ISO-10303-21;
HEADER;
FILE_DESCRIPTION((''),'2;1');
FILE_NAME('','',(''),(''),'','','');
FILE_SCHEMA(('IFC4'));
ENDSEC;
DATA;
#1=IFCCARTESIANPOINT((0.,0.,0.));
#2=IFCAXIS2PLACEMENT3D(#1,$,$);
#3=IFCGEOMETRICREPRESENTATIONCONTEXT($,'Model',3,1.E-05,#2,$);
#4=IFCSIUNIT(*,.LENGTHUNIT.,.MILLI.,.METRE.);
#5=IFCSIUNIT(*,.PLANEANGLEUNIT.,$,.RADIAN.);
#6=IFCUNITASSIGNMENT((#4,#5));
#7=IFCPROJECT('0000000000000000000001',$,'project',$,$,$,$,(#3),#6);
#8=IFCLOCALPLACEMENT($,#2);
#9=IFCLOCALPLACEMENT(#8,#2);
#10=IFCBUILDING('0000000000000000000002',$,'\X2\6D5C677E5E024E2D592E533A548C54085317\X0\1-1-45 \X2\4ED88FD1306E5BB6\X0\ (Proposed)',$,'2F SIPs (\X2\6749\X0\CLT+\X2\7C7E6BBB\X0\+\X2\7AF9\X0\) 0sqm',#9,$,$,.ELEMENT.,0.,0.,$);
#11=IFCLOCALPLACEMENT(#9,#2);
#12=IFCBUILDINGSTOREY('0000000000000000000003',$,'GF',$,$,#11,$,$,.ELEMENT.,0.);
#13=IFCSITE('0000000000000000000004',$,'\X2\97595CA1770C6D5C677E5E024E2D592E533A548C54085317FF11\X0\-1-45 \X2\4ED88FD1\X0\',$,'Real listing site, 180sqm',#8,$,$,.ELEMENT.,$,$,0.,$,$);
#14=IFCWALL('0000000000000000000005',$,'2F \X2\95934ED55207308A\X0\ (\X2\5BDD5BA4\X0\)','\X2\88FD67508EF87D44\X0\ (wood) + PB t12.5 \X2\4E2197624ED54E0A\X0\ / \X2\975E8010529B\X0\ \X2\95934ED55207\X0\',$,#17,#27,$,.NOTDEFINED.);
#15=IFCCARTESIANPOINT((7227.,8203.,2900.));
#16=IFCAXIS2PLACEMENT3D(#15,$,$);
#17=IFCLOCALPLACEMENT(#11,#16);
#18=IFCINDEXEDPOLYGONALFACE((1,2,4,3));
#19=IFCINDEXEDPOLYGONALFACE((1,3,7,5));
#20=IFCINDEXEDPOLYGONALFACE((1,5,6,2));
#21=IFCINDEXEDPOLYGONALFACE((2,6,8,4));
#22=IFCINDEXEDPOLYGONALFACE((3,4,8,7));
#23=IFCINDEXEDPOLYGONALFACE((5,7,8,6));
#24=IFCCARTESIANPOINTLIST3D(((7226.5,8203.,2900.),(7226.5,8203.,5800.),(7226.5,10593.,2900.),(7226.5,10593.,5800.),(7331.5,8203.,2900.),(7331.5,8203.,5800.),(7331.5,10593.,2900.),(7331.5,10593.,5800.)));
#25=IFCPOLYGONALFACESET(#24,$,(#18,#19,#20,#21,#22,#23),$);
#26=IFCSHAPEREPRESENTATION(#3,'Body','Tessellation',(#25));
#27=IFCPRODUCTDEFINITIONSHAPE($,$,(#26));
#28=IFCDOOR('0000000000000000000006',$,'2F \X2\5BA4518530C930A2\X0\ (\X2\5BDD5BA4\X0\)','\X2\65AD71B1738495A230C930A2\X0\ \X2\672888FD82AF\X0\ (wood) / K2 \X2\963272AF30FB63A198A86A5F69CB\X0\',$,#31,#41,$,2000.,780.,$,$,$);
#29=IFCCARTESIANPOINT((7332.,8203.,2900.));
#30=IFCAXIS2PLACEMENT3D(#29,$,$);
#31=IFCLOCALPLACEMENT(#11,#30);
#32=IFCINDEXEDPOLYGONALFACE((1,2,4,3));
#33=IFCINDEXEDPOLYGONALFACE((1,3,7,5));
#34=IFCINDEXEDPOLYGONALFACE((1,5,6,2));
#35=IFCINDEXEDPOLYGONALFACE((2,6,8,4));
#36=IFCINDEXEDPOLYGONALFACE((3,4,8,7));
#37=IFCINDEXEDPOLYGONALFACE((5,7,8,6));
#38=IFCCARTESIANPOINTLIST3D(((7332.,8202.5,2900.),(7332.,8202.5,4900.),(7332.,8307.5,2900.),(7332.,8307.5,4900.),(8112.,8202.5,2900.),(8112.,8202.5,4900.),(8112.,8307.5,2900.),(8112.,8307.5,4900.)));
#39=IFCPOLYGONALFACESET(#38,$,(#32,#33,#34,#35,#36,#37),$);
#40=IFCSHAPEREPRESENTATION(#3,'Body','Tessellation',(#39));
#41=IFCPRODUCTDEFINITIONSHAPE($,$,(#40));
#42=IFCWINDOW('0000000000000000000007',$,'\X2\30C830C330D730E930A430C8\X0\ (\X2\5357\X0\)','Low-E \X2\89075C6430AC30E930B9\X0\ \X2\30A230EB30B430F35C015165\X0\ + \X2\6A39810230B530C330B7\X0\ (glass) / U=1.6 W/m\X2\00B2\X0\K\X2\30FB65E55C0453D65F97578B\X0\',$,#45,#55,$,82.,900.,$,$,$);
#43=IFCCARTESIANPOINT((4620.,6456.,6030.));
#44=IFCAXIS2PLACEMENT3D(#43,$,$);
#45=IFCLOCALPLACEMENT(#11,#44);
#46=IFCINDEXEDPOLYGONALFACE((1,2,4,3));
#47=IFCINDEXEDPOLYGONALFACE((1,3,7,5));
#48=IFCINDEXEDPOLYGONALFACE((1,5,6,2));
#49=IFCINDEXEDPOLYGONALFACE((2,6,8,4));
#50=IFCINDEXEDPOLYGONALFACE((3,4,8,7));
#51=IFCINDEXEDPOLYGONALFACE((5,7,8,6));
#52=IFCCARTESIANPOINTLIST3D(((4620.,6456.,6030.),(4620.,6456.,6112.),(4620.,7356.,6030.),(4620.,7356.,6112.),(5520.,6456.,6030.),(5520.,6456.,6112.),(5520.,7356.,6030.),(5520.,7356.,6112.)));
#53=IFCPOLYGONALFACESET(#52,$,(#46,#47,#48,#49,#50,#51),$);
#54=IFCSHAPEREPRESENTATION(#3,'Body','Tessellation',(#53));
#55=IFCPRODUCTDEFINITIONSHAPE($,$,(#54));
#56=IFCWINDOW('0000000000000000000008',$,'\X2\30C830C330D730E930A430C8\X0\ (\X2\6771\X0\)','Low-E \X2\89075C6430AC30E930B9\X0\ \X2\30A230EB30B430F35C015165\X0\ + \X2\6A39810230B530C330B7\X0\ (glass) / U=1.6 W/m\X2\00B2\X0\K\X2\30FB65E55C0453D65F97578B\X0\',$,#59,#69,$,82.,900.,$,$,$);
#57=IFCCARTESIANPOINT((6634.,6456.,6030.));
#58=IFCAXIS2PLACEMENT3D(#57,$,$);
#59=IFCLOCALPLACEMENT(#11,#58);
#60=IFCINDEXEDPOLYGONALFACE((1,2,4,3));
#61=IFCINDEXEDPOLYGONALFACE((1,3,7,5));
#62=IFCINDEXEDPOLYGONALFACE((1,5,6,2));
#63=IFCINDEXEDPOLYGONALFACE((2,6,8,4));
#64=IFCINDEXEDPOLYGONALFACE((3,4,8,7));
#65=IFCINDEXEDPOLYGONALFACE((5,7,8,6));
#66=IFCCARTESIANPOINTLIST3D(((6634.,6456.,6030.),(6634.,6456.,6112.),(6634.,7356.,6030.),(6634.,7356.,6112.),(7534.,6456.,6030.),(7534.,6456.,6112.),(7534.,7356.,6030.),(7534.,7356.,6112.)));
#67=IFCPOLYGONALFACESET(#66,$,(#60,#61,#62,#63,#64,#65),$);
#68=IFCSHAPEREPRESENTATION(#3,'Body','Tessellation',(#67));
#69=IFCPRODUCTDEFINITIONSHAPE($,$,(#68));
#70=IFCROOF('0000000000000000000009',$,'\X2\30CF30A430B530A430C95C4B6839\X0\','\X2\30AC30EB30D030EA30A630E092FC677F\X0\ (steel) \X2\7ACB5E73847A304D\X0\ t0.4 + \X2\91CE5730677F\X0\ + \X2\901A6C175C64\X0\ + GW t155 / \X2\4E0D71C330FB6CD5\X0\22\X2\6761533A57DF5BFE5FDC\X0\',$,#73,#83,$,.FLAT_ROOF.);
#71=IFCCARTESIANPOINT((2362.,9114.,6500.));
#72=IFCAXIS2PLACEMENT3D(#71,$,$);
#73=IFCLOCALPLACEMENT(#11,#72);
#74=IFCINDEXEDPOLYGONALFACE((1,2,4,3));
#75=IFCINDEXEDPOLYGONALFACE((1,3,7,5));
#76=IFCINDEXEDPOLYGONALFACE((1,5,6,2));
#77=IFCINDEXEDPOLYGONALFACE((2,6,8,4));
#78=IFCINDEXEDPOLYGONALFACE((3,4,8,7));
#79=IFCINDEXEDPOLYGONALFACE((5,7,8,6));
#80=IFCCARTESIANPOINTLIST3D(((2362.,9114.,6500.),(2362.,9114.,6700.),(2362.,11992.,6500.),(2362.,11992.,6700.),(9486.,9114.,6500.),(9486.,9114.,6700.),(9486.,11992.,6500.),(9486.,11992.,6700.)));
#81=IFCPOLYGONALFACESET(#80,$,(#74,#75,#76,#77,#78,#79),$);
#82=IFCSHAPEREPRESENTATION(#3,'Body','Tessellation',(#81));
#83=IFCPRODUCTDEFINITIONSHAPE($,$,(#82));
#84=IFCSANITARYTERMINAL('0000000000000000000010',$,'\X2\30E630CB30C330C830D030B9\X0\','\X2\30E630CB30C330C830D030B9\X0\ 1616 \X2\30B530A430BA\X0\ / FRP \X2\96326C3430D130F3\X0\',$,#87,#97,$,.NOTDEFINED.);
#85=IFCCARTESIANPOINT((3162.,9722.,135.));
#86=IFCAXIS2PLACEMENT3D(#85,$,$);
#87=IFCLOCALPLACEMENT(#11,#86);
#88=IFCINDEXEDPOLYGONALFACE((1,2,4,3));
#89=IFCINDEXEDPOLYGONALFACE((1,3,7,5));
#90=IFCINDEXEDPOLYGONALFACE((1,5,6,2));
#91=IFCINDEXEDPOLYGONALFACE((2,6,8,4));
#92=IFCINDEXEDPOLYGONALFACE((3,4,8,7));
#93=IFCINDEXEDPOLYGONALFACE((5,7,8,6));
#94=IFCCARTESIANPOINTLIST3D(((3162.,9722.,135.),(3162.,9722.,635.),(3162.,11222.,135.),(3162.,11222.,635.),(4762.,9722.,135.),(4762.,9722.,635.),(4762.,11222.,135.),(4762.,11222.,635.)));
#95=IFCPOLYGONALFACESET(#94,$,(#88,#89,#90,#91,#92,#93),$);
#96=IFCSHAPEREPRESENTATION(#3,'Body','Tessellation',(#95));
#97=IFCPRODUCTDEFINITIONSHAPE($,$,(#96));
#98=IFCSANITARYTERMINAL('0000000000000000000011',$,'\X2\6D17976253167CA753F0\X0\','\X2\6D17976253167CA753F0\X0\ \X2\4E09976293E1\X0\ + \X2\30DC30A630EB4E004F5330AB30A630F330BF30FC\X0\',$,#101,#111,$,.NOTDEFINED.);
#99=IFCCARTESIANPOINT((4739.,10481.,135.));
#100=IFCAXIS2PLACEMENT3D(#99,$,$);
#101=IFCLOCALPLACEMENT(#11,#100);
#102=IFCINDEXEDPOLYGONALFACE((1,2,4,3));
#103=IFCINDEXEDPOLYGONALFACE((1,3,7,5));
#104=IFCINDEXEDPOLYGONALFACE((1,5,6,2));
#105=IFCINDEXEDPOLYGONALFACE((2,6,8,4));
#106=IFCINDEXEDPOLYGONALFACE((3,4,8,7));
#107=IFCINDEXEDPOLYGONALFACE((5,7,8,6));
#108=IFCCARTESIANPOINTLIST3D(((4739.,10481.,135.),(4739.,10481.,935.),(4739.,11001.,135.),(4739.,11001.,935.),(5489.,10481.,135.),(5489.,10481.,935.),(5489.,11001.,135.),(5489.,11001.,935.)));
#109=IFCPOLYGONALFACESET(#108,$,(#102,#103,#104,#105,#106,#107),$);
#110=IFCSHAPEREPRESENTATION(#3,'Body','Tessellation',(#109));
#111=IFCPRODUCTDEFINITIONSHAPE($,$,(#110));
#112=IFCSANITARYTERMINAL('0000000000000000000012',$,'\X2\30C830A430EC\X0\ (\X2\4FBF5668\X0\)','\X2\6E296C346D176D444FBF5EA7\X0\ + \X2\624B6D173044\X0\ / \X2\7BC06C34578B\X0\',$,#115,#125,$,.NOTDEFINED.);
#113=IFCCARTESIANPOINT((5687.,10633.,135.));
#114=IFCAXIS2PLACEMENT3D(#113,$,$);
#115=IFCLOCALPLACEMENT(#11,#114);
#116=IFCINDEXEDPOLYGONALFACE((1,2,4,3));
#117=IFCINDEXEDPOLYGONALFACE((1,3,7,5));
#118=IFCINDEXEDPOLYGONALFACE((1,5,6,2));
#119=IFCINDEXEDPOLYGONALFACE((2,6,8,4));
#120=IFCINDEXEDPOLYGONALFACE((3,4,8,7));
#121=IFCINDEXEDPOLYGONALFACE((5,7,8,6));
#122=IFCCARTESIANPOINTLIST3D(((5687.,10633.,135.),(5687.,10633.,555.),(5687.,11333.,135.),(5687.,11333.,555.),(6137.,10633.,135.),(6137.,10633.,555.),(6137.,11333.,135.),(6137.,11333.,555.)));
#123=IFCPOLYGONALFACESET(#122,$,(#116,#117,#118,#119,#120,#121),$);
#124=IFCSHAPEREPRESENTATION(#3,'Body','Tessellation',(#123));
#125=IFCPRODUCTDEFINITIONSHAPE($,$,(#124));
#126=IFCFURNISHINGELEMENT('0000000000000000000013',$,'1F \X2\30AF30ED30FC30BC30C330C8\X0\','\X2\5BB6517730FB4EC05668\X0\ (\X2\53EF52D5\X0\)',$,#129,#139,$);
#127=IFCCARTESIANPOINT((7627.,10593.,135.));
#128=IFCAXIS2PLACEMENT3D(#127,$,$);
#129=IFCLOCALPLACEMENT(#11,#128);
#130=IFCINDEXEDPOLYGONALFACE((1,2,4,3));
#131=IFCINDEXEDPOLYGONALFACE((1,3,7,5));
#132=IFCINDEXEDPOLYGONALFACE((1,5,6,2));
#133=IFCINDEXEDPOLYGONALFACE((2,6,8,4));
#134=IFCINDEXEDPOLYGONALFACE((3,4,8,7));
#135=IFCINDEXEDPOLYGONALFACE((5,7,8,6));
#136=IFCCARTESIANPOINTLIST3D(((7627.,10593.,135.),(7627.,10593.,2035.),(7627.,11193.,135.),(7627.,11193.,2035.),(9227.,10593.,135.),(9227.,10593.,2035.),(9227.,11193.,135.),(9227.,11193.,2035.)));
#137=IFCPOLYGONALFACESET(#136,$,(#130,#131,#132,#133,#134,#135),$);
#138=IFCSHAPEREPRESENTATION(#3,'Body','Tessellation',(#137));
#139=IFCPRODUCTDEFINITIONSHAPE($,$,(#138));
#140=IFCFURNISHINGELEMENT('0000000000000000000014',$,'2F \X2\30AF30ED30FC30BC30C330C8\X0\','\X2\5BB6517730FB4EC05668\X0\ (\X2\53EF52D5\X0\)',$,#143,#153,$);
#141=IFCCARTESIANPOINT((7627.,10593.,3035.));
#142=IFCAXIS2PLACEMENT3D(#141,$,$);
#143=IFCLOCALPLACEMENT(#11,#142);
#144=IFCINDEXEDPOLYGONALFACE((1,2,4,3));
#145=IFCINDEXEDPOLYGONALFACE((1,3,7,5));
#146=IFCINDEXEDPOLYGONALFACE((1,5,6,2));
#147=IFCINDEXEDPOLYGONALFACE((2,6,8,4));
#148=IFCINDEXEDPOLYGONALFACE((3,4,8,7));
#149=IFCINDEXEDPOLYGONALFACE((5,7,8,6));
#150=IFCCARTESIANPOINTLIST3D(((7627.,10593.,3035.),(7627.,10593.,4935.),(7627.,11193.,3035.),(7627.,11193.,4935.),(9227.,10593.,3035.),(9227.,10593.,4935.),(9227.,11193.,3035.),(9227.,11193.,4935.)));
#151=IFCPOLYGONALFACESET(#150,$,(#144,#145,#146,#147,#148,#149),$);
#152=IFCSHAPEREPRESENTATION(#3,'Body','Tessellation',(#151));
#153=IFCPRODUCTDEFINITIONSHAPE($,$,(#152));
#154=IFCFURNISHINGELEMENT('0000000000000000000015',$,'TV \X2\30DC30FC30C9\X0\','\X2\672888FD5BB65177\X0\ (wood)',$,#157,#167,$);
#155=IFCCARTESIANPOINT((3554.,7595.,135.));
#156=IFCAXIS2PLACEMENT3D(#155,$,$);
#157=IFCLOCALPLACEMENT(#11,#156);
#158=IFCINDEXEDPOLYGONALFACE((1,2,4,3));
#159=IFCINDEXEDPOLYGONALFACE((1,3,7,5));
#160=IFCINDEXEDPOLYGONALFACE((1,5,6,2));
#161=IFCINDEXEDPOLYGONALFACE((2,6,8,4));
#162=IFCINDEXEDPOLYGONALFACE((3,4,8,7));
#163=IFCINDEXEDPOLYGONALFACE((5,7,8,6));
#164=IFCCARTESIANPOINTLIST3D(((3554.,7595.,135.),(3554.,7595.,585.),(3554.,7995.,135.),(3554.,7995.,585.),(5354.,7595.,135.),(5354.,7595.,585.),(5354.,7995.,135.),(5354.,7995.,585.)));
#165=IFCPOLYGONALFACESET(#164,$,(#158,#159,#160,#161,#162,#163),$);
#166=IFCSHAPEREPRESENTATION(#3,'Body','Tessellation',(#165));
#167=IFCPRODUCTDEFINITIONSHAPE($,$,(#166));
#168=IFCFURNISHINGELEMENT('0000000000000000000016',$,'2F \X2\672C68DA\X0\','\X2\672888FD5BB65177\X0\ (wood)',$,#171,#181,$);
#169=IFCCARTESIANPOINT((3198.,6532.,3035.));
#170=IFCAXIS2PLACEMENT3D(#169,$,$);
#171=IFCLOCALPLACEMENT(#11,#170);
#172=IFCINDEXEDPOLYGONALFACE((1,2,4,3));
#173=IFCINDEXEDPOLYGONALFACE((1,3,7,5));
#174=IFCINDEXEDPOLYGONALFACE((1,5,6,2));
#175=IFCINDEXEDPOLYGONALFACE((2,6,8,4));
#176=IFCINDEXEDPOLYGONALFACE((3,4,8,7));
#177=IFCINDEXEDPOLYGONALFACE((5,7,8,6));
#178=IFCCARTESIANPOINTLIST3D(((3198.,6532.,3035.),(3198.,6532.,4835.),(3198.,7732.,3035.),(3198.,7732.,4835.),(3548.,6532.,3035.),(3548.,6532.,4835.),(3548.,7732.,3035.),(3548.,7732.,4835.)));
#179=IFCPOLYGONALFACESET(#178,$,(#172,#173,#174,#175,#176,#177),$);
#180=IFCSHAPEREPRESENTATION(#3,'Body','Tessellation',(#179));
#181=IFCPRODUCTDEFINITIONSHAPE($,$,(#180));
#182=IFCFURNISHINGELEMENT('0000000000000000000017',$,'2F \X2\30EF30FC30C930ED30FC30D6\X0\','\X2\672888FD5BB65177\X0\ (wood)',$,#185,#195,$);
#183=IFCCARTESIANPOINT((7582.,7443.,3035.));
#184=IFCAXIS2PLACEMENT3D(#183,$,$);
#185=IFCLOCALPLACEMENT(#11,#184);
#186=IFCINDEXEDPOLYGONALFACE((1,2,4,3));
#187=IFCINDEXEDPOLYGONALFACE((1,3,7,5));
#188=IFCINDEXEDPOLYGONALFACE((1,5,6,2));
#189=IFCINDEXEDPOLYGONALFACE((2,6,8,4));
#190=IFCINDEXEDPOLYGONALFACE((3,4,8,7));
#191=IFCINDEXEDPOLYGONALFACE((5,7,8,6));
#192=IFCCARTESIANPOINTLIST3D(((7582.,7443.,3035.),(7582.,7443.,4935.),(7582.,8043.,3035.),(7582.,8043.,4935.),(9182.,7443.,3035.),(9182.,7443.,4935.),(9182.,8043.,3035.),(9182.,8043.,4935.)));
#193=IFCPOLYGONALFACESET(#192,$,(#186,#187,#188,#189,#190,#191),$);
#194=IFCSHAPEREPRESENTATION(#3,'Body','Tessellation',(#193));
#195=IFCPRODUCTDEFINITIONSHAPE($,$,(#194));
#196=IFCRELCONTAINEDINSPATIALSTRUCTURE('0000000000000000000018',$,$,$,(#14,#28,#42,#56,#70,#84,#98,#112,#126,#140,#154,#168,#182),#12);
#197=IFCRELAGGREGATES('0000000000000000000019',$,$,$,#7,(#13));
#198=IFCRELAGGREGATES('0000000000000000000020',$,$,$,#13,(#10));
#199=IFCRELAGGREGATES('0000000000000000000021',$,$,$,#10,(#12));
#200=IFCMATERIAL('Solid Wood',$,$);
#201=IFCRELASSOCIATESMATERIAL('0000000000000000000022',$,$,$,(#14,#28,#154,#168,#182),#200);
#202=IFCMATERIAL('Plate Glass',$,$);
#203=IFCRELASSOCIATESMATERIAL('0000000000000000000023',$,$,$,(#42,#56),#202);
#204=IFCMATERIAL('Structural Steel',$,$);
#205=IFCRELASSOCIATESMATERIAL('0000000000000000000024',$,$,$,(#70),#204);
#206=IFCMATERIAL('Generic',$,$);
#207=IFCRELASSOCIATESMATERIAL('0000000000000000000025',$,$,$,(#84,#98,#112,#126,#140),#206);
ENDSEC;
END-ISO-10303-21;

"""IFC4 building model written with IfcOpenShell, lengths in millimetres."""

from ifc_helpers import new_model, si_unit, frame, frame_2d, origin, place, context, project, spatial, rectangle, extrude, material, element, save


model = new_model("IFC4")

# Units and contexts
model_context = context("Model", 3, precision=1e-05, world=origin())
ifc_project = project(units=[si_unit("LENGTHUNIT", "METRE", prefix="MILLI"), si_unit("PLANEANGLEUNIT", "RADIAN")], contexts=[model_context])

# Site, building, storey
site_placement = place(None, origin())
site = spatial("IfcSite", under=ifc_project, at=site_placement, Name="静岡県浜松市中央区和合北１-1-45 付近", ObjectType="Real listing site, 180sqm", CompositionType="ELEMENT", RefElevation=0.0)
building_placement = place(site_placement, origin())
building = spatial("IfcBuilding", under=site, at=building_placement, Name="浜松市中央区和合北1-1-45 付近の家 (Proposed)", ObjectType="2F SIPs (杉CLT+籾殻+竹) 0sqm", CompositionType="ELEMENT", ElevationOfRefHeight=0.0, ElevationOfTerrain=0.0)
storey_placement = place(building_placement, origin())
storey = spatial("IfcBuildingStorey", under=building, at=storey_placement, Name="GF", CompositionType="ELEMENT", Elevation=0.0)

# Shared definitions
ifc_material_1 = material(Name="Solid Wood")
ifc_material_2 = material(Name="Plate Glass")

# Wall
wall_1_placement = place(storey_placement, frame((7227.0, 8203.0, 2900.0)))
element("IfcWall", 1, at=wall_1_placement, inside=storey, material=ifc_material_1, Name="2F 間仕切り (寝室)", Description="製材軸組 (wood) + PB t12.5 両面仕上 / 非耐力 間仕切", PredefinedType="NOTDEFINED", context=model_context, shape_type="SweptSolid", body=[
    extrude(rectangle(XDim=105.0, YDim=2390.0, at=frame_2d((52.0, 1195.0))), frame((7227.0, 8203.0, 2900.0)), (0.0, 0.0, 1.0), 2900.0),
])

# Door
door_1_placement = place(storey_placement, frame((7332.0, 8203.0, 2900.0)))
element("IfcDoor", 2, at=door_1_placement, inside=storey, material=ifc_material_1, Name="2F 室内ドア (寝室)", Description="断熱玄関ドア 木製芯 (wood) / K2 防犯・採風機構", OverallHeight=2000.0, OverallWidth=780.0, context=model_context, shape_type="SweptSolid", body=[
    extrude(rectangle(XDim=780.0, YDim=105.0, at=frame_2d((390.0, 52.0))), frame((7332.0, 8203.0, 2900.0)), (0.0, 0.0, 1.0), 2000.0),
])

# Windows
window_1_placement = place(storey_placement, frame((4620.0, 6456.0, 6030.0)))
element("IfcWindow", 3, at=window_1_placement, inside=storey, material=ifc_material_2, Name="トップライト (南)", Description="Low-E 複層ガラス アルゴン封入 + 樹脂サッシ (glass) / U=1.6 W/m²K・日射取得型", OverallHeight=82.0, OverallWidth=900.0, context=model_context, shape_type="SweptSolid", body=[
    extrude(rectangle(XDim=900.0, YDim=900.0, at=frame_2d((450.0, 450.0))), frame((4620.0, 6456.0, 6030.0)), (0.0, 0.0, 1.0), 82.0),
])
window_2_placement = place(storey_placement, frame((6634.0, 6456.0, 6030.0)))
element("IfcWindow", 4, at=window_2_placement, inside=storey, material=ifc_material_2, Name="トップライト (東)", Description="Low-E 複層ガラス アルゴン封入 + 樹脂サッシ (glass) / U=1.6 W/m²K・日射取得型", OverallHeight=82.0, OverallWidth=900.0, context=model_context, shape_type="SweptSolid", body=[
    extrude(rectangle(XDim=900.0, YDim=900.0, at=frame_2d((450.0, 450.0))), frame((6634.0, 6456.0, 6030.0)), (0.0, 0.0, 1.0), 82.0),
])

# Roof
ifc_material_3 = material(Name="Structural Steel")
roof_placement = place(storey_placement, frame((2362.0, 9114.0, 6500.0)))
element("IfcRoof", 5, at=roof_placement, inside=storey, material=ifc_material_3, Name="ハイサイド屋根", Description="ガルバリウム鋼板 (steel) 立平葺き t0.4 + 野地板 + 通気層 + GW t155 / 不燃・法22条区域対応", PredefinedType="FLAT_ROOF", context=model_context, shape_type="SweptSolid", body=[
    extrude(rectangle(XDim=7124.0, YDim=2878.0, at=frame_2d((3562.0, 1439.0))), frame((2362.0, 9114.0, 6500.0)), (0.0, 0.0, 1.0), 200.0),
])

# Sanitary terminals
ifc_material_4 = material(Name="Generic")
sanitary_terminal_1_placement = place(storey_placement, frame((3162.0, 9722.0, 135.0)))
element("IfcSanitaryTerminal", 6, at=sanitary_terminal_1_placement, inside=storey, material=ifc_material_4, Name="ユニットバス", Description="ユニットバス 1616 サイズ / FRP 防水パン", PredefinedType="NOTDEFINED", context=model_context, shape_type="SweptSolid", body=[
    extrude(rectangle(XDim=1600.0, YDim=1500.0, at=frame_2d((800.0, 750.0))), frame((3162.0, 9722.0, 135.0)), (0.0, 0.0, 1.0), 500.0),
])
sanitary_terminal_2_placement = place(storey_placement, frame((4739.0, 10481.0, 135.0)))
element("IfcSanitaryTerminal", 7, at=sanitary_terminal_2_placement, inside=storey, material=ifc_material_4, Name="洗面化粧台", Description="洗面化粧台 三面鏡 + ボウル一体カウンター", PredefinedType="NOTDEFINED", context=model_context, shape_type="SweptSolid", body=[
    extrude(rectangle(XDim=750.0, YDim=520.0, at=frame_2d((375.0, 260.0))), frame((4739.0, 10481.0, 135.0)), (0.0, 0.0, 1.0), 800.0),
])
sanitary_terminal_3_placement = place(storey_placement, frame((5687.0, 10633.0, 135.0)))
element("IfcSanitaryTerminal", 8, at=sanitary_terminal_3_placement, inside=storey, material=ifc_material_4, Name="トイレ (便器)", Description="温水洗浄便座 + 手洗い / 節水型", PredefinedType="NOTDEFINED", context=model_context, shape_type="SweptSolid", body=[
    extrude(rectangle(XDim=450.0, YDim=700.0, at=frame_2d((225.0, 350.0))), frame((5687.0, 10633.0, 135.0)), (0.0, 0.0, 1.0), 420.0),
])

# Furnishing elements
furnishing_1_placement = place(storey_placement, frame((7627.0, 10593.0, 135.0)))
element("IfcFurnishingElement", 9, at=furnishing_1_placement, inside=storey, material=ifc_material_4, Name="1F クローゼット", Description="家具・什器 (可動)", context=model_context, shape_type="SweptSolid", body=[
    extrude(rectangle(XDim=1600.0, YDim=600.0, at=frame_2d((800.0, 300.0))), frame((7627.0, 10593.0, 135.0)), (0.0, 0.0, 1.0), 1900.0),
])
furnishing_2_placement = place(storey_placement, frame((7627.0, 10593.0, 3035.0)))
element("IfcFurnishingElement", 10, at=furnishing_2_placement, inside=storey, material=ifc_material_4, Name="2F クローゼット", Description="家具・什器 (可動)", context=model_context, shape_type="SweptSolid", body=[
    extrude(rectangle(XDim=1600.0, YDim=600.0, at=frame_2d((800.0, 300.0))), frame((7627.0, 10593.0, 3035.0)), (0.0, 0.0, 1.0), 1900.0),
])
furnishing_3_placement = place(storey_placement, frame((3554.0, 7595.0, 135.0)))
element("IfcFurnishingElement", 11, at=furnishing_3_placement, inside=storey, material=ifc_material_1, Name="TV ボード", Description="木製家具 (wood)", context=model_context, shape_type="SweptSolid", body=[
    extrude(rectangle(XDim=1800.0, YDim=400.0, at=frame_2d((900.0, 200.0))), frame((3554.0, 7595.0, 135.0)), (0.0, 0.0, 1.0), 450.0),
])
furnishing_4_placement = place(storey_placement, frame((3198.0, 6532.0, 3035.0)))
element("IfcFurnishingElement", 12, at=furnishing_4_placement, inside=storey, material=ifc_material_1, Name="2F 本棚", Description="木製家具 (wood)", context=model_context, shape_type="SweptSolid", body=[
    extrude(rectangle(XDim=350.0, YDim=1200.0, at=frame_2d((175.0, 600.0))), frame((3198.0, 6532.0, 3035.0)), (0.0, 0.0, 1.0), 1800.0),
])
furnishing_5_placement = place(storey_placement, frame((7582.0, 7443.0, 3035.0)))
element("IfcFurnishingElement", 13, at=furnishing_5_placement, inside=storey, material=ifc_material_1, Name="2F ワードローブ", Description="木製家具 (wood)", context=model_context, shape_type="SweptSolid", body=[
    extrude(rectangle(XDim=1600.0, YDim=600.0, at=frame_2d((800.0, 300.0))), frame((7582.0, 7443.0, 3035.0)), (0.0, 0.0, 1.0), 1900.0),
])

save(model, "model.ifc")
